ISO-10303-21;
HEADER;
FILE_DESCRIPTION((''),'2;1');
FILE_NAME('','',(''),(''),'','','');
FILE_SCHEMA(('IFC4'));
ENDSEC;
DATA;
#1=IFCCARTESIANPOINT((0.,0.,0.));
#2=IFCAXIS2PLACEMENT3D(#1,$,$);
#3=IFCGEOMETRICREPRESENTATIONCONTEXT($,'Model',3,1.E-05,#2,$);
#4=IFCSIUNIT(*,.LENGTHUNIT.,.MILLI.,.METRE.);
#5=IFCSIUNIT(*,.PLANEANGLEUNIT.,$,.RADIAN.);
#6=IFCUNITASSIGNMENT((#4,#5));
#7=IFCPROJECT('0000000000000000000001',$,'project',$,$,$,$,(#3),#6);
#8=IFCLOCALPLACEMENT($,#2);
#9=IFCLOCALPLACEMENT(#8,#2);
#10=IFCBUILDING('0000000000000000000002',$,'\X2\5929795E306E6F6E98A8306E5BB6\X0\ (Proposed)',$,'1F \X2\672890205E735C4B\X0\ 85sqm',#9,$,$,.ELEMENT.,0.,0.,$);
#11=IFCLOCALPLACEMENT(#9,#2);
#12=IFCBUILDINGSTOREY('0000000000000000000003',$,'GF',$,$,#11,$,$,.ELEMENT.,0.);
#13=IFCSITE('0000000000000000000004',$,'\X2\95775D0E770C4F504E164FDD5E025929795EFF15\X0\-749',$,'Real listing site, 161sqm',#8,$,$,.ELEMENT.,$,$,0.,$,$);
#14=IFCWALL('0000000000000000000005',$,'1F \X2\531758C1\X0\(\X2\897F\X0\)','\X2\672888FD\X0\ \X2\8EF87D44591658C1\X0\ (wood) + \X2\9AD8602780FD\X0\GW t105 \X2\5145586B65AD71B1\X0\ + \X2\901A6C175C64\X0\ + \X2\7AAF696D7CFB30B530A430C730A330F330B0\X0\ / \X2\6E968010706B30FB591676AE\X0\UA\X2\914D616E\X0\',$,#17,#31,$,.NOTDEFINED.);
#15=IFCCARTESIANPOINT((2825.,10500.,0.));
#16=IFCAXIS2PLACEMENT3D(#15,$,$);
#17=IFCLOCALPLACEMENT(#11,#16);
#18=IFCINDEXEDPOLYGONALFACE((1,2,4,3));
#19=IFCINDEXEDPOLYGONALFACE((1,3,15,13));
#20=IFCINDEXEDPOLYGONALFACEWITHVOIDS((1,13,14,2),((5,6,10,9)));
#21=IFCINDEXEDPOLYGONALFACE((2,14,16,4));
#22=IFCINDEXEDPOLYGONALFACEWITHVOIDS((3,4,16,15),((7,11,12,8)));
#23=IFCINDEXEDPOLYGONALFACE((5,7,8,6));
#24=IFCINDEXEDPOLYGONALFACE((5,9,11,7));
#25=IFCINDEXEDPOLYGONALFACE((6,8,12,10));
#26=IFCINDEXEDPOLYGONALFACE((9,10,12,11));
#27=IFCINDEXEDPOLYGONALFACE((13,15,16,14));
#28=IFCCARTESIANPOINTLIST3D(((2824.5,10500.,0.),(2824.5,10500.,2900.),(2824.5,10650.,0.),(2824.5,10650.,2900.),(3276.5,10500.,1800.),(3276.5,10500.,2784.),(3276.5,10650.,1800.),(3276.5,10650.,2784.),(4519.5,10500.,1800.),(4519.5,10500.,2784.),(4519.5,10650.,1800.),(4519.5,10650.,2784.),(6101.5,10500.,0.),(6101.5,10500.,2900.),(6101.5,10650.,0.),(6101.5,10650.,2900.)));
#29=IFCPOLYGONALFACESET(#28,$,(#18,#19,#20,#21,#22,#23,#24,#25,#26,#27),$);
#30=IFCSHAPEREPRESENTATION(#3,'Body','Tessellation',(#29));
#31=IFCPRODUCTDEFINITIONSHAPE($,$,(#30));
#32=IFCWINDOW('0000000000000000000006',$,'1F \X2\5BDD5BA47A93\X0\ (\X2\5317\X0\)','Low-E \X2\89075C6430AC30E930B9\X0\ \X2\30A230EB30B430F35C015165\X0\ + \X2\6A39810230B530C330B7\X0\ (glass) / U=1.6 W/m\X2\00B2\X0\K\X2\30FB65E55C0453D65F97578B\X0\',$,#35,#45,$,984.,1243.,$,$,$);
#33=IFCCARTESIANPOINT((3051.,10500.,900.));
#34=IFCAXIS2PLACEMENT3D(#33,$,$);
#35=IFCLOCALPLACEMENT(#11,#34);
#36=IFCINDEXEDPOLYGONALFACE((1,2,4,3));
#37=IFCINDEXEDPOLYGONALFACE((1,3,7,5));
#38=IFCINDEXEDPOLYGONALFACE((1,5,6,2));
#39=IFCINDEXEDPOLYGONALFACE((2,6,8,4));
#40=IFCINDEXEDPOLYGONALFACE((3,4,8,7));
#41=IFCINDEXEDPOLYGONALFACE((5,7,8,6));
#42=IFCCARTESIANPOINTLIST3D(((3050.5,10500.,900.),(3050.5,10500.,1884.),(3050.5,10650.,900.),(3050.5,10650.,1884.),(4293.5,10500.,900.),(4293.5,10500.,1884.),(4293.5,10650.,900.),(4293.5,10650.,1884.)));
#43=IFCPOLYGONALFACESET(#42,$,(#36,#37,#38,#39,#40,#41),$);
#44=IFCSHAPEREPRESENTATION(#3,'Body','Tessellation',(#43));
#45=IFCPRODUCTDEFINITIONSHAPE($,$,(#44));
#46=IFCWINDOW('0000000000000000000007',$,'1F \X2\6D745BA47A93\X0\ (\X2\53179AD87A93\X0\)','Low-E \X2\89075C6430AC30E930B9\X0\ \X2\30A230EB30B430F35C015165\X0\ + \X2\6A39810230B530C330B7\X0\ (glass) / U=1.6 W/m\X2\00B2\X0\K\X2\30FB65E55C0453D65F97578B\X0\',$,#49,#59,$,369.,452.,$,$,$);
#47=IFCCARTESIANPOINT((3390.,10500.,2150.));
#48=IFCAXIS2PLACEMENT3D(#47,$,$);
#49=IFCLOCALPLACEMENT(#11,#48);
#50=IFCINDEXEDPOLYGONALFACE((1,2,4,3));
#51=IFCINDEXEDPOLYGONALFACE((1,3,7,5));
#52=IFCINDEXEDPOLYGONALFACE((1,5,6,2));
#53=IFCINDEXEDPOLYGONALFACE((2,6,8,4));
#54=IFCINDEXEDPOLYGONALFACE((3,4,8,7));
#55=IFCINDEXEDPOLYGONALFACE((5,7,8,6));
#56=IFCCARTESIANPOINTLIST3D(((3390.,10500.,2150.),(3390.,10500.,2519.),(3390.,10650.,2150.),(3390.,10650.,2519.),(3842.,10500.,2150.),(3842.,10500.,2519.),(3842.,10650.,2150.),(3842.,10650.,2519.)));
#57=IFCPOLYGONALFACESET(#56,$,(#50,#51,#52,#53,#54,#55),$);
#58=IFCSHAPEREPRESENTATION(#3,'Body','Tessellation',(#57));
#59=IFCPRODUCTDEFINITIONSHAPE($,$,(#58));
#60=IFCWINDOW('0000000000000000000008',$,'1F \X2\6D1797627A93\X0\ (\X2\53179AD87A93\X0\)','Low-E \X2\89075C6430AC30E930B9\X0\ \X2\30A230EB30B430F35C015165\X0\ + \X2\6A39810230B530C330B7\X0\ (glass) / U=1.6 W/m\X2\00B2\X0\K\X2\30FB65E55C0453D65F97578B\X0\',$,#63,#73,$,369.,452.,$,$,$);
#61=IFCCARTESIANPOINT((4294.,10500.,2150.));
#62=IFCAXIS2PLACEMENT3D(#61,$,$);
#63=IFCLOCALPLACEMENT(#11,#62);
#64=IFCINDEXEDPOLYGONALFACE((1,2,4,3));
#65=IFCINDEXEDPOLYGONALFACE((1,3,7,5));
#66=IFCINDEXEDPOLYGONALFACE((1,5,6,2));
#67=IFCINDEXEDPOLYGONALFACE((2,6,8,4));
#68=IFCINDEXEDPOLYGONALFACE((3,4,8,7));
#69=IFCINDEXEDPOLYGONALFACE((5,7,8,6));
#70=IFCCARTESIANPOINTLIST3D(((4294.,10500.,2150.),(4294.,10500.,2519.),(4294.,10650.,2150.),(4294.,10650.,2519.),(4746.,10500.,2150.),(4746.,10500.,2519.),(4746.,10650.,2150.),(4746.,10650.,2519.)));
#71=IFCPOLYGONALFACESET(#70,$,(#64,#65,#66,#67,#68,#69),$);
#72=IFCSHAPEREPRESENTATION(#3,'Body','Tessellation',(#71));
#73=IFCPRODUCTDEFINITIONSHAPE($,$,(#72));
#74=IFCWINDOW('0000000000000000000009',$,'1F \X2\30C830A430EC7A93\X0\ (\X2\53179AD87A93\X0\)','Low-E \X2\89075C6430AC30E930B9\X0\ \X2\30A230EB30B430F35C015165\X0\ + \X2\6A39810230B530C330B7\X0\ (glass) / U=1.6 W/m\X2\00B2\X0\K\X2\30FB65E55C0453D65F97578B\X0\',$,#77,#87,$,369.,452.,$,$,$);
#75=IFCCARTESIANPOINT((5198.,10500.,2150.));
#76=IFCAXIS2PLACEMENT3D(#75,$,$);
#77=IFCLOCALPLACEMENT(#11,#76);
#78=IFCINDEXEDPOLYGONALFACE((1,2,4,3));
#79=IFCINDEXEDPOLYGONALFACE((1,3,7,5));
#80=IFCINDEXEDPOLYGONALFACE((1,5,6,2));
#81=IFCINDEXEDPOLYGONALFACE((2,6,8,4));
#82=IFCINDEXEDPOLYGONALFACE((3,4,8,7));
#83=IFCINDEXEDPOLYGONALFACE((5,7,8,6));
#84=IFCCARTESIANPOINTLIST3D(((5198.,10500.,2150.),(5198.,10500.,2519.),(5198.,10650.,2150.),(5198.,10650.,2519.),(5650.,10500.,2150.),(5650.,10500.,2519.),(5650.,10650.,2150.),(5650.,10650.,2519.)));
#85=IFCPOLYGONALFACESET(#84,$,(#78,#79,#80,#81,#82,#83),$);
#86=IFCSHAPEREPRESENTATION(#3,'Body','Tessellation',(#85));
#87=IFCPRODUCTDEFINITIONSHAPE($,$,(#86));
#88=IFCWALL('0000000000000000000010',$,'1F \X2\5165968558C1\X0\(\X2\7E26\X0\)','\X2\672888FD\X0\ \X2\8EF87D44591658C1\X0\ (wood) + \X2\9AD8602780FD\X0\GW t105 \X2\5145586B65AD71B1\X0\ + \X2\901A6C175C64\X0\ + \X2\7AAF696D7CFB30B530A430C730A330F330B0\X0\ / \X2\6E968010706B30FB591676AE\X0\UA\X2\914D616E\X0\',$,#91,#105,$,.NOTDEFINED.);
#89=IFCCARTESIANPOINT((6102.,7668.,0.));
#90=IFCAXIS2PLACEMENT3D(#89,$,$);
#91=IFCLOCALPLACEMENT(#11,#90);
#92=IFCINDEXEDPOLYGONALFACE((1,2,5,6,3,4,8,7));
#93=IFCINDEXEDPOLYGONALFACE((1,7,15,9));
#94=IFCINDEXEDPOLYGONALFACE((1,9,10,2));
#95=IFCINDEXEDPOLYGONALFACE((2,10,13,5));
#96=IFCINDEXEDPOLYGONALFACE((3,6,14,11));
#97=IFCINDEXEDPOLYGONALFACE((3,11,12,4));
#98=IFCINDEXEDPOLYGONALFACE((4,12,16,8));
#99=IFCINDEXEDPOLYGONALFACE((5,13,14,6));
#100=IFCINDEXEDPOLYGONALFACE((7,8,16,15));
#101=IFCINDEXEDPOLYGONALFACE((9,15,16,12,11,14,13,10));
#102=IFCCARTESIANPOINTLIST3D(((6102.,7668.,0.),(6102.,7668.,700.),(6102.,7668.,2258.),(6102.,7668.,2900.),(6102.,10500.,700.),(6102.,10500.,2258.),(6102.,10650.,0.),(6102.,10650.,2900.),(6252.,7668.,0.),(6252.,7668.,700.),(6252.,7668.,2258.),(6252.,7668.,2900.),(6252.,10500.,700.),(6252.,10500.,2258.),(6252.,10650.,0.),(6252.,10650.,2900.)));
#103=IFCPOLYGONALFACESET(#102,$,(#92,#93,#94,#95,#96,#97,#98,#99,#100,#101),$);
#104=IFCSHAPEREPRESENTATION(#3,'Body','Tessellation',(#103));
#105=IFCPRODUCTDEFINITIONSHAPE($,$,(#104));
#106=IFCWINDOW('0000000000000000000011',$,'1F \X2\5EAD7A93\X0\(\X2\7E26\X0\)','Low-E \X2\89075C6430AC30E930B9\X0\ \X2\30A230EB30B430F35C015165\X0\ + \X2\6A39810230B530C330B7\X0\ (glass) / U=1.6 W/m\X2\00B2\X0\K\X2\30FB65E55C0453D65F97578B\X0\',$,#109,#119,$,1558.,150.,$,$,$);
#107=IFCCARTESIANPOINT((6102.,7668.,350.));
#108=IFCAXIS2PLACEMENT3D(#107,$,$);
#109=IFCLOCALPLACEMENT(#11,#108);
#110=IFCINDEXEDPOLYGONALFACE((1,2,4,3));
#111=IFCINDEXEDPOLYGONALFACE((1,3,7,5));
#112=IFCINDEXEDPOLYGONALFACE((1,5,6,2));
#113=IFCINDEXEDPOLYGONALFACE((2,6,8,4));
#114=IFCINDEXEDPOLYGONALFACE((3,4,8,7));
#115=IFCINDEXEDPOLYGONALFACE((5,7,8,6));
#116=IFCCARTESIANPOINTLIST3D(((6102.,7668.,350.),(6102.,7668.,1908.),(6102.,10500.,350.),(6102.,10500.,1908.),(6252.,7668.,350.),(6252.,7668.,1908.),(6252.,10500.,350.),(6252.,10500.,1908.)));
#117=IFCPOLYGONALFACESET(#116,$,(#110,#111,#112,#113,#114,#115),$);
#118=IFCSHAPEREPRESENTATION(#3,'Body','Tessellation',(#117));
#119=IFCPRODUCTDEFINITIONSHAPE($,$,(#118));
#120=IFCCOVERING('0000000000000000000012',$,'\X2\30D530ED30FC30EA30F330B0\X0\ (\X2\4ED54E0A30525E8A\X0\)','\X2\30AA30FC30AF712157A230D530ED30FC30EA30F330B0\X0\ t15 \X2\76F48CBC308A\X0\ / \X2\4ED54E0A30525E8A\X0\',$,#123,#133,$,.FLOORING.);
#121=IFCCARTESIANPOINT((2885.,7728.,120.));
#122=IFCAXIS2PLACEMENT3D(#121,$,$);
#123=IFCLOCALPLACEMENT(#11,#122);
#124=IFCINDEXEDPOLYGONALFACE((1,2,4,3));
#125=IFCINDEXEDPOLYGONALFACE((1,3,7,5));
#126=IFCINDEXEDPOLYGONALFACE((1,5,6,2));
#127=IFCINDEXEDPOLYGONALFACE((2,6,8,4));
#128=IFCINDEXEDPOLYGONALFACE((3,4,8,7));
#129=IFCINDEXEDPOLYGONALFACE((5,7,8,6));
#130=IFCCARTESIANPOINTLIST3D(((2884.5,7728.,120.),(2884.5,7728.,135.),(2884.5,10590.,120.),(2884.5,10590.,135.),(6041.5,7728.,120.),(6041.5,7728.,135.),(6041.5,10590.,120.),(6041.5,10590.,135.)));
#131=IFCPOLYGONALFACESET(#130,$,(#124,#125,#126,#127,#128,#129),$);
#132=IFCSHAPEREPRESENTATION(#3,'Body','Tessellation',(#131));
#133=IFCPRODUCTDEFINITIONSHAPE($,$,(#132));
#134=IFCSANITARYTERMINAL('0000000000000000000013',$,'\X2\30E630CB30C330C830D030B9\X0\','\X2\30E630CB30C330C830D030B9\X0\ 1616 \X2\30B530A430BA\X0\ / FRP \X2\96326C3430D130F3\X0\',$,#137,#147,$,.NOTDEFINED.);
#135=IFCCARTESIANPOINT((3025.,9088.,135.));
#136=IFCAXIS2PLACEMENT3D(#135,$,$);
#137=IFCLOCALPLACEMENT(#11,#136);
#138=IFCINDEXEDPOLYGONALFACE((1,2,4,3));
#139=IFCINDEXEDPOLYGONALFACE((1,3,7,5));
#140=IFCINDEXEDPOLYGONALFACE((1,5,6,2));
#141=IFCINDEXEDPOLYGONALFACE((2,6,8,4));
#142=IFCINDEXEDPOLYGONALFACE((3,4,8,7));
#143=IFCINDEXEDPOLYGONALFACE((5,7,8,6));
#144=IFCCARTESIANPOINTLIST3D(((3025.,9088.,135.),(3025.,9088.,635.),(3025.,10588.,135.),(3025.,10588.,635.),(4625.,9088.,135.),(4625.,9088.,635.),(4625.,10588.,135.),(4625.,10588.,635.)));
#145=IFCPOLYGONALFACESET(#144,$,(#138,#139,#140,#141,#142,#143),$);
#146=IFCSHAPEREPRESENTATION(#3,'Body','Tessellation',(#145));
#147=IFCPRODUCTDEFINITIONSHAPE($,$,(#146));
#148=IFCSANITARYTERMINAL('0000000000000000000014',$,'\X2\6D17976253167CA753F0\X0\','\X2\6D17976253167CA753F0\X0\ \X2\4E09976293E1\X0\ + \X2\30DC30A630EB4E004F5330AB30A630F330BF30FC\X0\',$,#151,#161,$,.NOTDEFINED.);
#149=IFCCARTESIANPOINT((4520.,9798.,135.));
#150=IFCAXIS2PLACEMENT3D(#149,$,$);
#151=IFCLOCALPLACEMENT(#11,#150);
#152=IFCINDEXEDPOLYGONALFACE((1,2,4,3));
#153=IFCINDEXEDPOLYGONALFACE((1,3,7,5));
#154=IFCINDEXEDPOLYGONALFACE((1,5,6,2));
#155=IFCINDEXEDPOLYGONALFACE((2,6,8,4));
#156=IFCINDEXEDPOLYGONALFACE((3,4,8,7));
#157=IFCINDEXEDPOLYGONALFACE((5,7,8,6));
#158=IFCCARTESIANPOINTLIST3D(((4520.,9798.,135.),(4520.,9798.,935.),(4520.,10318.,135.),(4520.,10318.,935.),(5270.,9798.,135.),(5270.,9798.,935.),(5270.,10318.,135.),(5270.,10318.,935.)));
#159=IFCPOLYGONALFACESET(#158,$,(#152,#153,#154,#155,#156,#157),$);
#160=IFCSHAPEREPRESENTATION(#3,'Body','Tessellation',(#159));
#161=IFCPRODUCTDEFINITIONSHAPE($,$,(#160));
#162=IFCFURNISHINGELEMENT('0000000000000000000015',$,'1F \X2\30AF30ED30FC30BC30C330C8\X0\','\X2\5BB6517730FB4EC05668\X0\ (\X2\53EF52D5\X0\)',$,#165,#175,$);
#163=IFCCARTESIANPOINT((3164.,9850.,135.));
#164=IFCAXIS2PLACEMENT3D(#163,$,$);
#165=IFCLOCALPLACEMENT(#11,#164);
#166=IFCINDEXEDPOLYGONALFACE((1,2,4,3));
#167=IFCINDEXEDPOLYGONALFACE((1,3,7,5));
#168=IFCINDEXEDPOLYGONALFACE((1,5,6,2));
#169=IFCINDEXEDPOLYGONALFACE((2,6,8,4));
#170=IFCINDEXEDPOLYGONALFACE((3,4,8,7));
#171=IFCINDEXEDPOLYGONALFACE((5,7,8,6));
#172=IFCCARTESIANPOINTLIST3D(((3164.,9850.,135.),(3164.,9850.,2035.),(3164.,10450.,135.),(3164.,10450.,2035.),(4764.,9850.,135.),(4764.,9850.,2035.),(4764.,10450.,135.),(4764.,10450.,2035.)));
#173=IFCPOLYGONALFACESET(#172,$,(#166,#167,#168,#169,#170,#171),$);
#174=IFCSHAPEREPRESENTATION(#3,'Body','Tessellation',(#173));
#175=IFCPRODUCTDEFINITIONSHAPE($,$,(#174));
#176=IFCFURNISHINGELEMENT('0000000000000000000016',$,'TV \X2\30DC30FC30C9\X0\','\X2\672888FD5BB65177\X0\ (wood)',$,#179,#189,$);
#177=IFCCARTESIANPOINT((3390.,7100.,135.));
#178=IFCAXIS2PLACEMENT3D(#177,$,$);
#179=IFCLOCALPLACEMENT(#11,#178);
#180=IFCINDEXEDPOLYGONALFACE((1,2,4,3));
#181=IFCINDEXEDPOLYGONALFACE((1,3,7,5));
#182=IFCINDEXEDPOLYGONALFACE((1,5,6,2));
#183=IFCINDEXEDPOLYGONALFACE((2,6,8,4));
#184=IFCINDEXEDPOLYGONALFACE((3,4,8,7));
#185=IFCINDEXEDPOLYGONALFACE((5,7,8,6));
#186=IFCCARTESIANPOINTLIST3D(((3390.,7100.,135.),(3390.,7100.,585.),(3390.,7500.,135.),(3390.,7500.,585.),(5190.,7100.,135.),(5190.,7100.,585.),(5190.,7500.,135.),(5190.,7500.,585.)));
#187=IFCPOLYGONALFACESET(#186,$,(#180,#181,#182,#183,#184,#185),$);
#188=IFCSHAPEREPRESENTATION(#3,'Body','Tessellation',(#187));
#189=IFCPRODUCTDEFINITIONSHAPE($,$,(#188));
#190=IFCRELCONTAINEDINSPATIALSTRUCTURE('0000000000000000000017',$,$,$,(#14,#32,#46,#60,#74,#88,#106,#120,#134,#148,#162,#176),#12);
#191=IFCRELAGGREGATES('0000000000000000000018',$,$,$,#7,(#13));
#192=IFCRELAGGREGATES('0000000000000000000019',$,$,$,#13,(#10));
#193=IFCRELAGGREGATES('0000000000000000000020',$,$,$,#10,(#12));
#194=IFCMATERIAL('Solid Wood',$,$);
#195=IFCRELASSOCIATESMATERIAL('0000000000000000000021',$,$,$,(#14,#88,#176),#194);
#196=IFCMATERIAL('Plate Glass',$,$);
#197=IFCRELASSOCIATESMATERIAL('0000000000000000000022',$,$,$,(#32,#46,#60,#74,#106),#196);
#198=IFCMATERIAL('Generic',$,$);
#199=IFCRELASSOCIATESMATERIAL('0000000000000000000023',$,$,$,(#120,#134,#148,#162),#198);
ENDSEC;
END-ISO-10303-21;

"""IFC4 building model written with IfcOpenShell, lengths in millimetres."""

from ifc_helpers import new_model, si_unit, frame, frame_2d, origin, place, context, project, spatial, rectangle, extrude, material, element, fill, save


model = new_model("IFC4")

# Units and contexts
model_context = context("Model", 3, precision=1e-05, world=origin())
ifc_project = project(units=[si_unit("LENGTHUNIT", "METRE", prefix="MILLI"), si_unit("PLANEANGLEUNIT", "RADIAN")], contexts=[model_context])

# Site, building, storey
site_placement = place(None, origin())
site = spatial("IfcSite", under=ifc_project, at=site_placement, Name="長崎県佐世保市天神５-749", ObjectType="Real listing site, 161sqm", CompositionType="ELEMENT", RefElevation=0.0)
building_placement = place(site_placement, origin())
building = spatial("IfcBuilding", under=site, at=building_placement, Name="天神の潮風の家 (Proposed)", ObjectType="1F 木造平屋 85sqm", CompositionType="ELEMENT", ElevationOfRefHeight=0.0, ElevationOfTerrain=0.0)
storey_placement = place(building_placement, origin())
storey = spatial("IfcBuildingStorey", under=building, at=storey_placement, Name="GF", CompositionType="ELEMENT", Elevation=0.0)

# Shared definitions
ifc_material_1 = material(Name="Solid Wood")

# Wall, openings, windows
wall_1_placement = place(storey_placement, frame((2825.0, 10500.0, 0.0)))
wall_1 = element("IfcWall", 1, at=wall_1_placement, inside=storey, material=ifc_material_1, Name="1F 北壁(西)", Description="木製 軸組外壁 (wood) + 高性能GW t105 充填断熱 + 通気層 + 窯業系サイディング / 準耐火・外皮UA配慮", PredefinedType="NOTDEFINED", context=model_context, shape_type="SweptSolid", body=[
    extrude(rectangle(XDim=3277.0, YDim=150.0, at=frame_2d((1638.0, 75.0))), frame((2825.0, 10500.0, 0.0)), (0.0, 0.0, 1.0), 2900.0),
])
opening_1_placement = place(storey_placement, frame((3051.0, 10500.0, 900.0)))
opening_1 = element("IfcOpeningElement", 2, at=opening_1_placement, cuts=wall_1, PredefinedType="NOTDEFINED", context=model_context, shape_type="SweptSolid", body=[
    extrude(rectangle(XDim=1243.0, YDim=150.0, at=frame_2d((621.0, 75.0))), frame((3051.0, 10500.0, 900.0)), (0.0, 0.0, 1.0), 984.0),
])
opening_2_placement = place(storey_placement, frame((3390.0, 10500.0, 2150.0)))
opening_2 = element("IfcOpeningElement", 3, at=opening_2_placement, cuts=wall_1, PredefinedType="NOTDEFINED", context=model_context, shape_type="SweptSolid", body=[
    extrude(rectangle(XDim=452.0, YDim=150.0, at=frame_2d((226.0, 75.0))), frame((3390.0, 10500.0, 2150.0)), (0.0, 0.0, 1.0), 369.0),
])
opening_3_placement = place(storey_placement, frame((4294.0, 10500.0, 2150.0)))
opening_3 = element("IfcOpeningElement", 4, at=opening_3_placement, cuts=wall_1, PredefinedType="NOTDEFINED", context=model_context, shape_type="SweptSolid", body=[
    extrude(rectangle(XDim=452.0, YDim=150.0, at=frame_2d((226.0, 75.0))), frame((4294.0, 10500.0, 2150.0)), (0.0, 0.0, 1.0), 369.0),
])
opening_4_placement = place(storey_placement, frame((5198.0, 10500.0, 2150.0)))
opening_4 = element("IfcOpeningElement", 5, at=opening_4_placement, cuts=wall_1, PredefinedType="NOTDEFINED", context=model_context, shape_type="SweptSolid", body=[
    extrude(rectangle(XDim=452.0, YDim=150.0, at=frame_2d((226.0, 75.0))), frame((5198.0, 10500.0, 2150.0)), (0.0, 0.0, 1.0), 369.0),
])
ifc_material_2 = material(Name="Plate Glass")
window_1_placement = place(storey_placement, frame((3051.0, 10500.0, 900.0)))
window_1 = element("IfcWindow", 6, at=window_1_placement, inside=storey, material=ifc_material_2, Name="1F 寝室窓 (北)", Description="Low-E 複層ガラス アルゴン封入 + 樹脂サッシ (glass) / U=1.6 W/m²K・日射取得型", OverallHeight=984.0, OverallWidth=1243.0, context=model_context, shape_type="SweptSolid", body=[
    extrude(rectangle(XDim=1243.0, YDim=150.0, at=frame_2d((621.0, 75.0))), frame((3051.0, 10500.0, 900.0)), (0.0, 0.0, 1.0), 984.0),
])
fill(opening_1, window_1)
window_2_placement = place(storey_placement, frame((3390.0, 10500.0, 2150.0)))
window_2 = element("IfcWindow", 7, at=window_2_placement, inside=storey, material=ifc_material_2, Name="1F 浴室窓 (北高窓)", Description="Low-E 複層ガラス アルゴン封入 + 樹脂サッシ (glass) / U=1.6 W/m²K・日射取得型", OverallHeight=369.0, OverallWidth=452.0, context=model_context, shape_type="SweptSolid", body=[
    extrude(rectangle(XDim=452.0, YDim=150.0, at=frame_2d((226.0, 75.0))), frame((3390.0, 10500.0, 2150.0)), (0.0, 0.0, 1.0), 369.0),
])
fill(opening_2, window_2)
window_3_placement = place(storey_placement, frame((4294.0, 10500.0, 2150.0)))
window_3 = element("IfcWindow", 8, at=window_3_placement, inside=storey, material=ifc_material_2, Name="1F 洗面窓 (北高窓)", Description="Low-E 複層ガラス アルゴン封入 + 樹脂サッシ (glass) / U=1.6 W/m²K・日射取得型", OverallHeight=369.0, OverallWidth=452.0, context=model_context, shape_type="SweptSolid", body=[
    extrude(rectangle(XDim=452.0, YDim=150.0, at=frame_2d((226.0, 75.0))), frame((4294.0, 10500.0, 2150.0)), (0.0, 0.0, 1.0), 369.0),
])
fill(opening_3, window_3)
window_4_placement = place(storey_placement, frame((5198.0, 10500.0, 2150.0)))
window_4 = element("IfcWindow", 9, at=window_4_placement, inside=storey, material=ifc_material_2, Name="1F トイレ窓 (北高窓)", Description="Low-E 複層ガラス アルゴン封入 + 樹脂サッシ (glass) / U=1.6 W/m²K・日射取得型", OverallHeight=369.0, OverallWidth=452.0, context=model_context, shape_type="SweptSolid", body=[
    extrude(rectangle(XDim=452.0, YDim=150.0, at=frame_2d((226.0, 75.0))), frame((5198.0, 10500.0, 2150.0)), (0.0, 0.0, 1.0), 369.0),
])
fill(opening_4, window_4)

# Wall, opening, window
wall_2_placement = place(storey_placement, frame((6102.0, 7668.0, 0.0)))
wall_2 = element("IfcWall", 10, at=wall_2_placement, inside=storey, material=ifc_material_1, Name="1F 入隅壁(縦)", Description="木製 軸組外壁 (wood) + 高性能GW t105 充填断熱 + 通気層 + 窯業系サイディング / 準耐火・外皮UA配慮", PredefinedType="NOTDEFINED", context=model_context, shape_type="SweptSolid", body=[
    extrude(rectangle(XDim=150.0, YDim=2982.0, at=frame_2d((75.0, 1491.0))), frame((6102.0, 7668.0, 0.0)), (0.0, 0.0, 1.0), 2900.0),
])
opening_5_placement = place(storey_placement, frame((6102.0, 7668.0, 350.0)))
opening_5 = element("IfcOpeningElement", 11, at=opening_5_placement, cuts=wall_2, PredefinedType="NOTDEFINED", context=model_context, shape_type="SweptSolid", body=[
    extrude(rectangle(XDim=150.0, YDim=2832.0, at=frame_2d((75.0, 1416.0))), frame((6102.0, 7668.0, 350.0)), (0.0, 0.0, 1.0), 1558.0),
])
window_5_placement = place(storey_placement, frame((6102.0, 7668.0, 350.0)))
window_5 = element("IfcWindow", 12, at=window_5_placement, inside=storey, material=ifc_material_2, Name="1F 庭窓(縦)", Description="Low-E 複層ガラス アルゴン封入 + 樹脂サッシ (glass) / U=1.6 W/m²K・日射取得型", OverallHeight=1558.0, OverallWidth=150.0, context=model_context, shape_type="SweptSolid", body=[
    extrude(rectangle(XDim=150.0, YDim=2832.0, at=frame_2d((75.0, 1416.0))), frame((6102.0, 7668.0, 350.0)), (0.0, 0.0, 1.0), 1558.0),
])
fill(opening_5, window_5)

# Covering
ifc_material_3 = material(Name="Generic")
covering_placement = place(storey_placement, frame((2885.0, 7728.0, 120.0)))
element("IfcCovering", 13, at=covering_placement, inside=storey, material=ifc_material_3, Name="フローリング (仕上げ床)", Description="オーク無垢フローリング t15 直貼り / 仕上げ床", PredefinedType="FLOORING", context=model_context, shape_type="SweptSolid", body=[
    extrude(rectangle(XDim=3157.0, YDim=2862.0, at=frame_2d((1578.0, 1431.0))), frame((2885.0, 7728.0, 120.0)), (0.0, 0.0, 1.0), 15.0),
])

# Sanitary terminals
sanitary_terminal_1_placement = place(storey_placement, frame((3025.0, 9088.0, 135.0)))
element("IfcSanitaryTerminal", 14, at=sanitary_terminal_1_placement, inside=storey, material=ifc_material_3, Name="ユニットバス", Description="ユニットバス 1616 サイズ / FRP 防水パン", PredefinedType="NOTDEFINED", context=model_context, shape_type="SweptSolid", body=[
    extrude(rectangle(XDim=1600.0, YDim=1500.0, at=frame_2d((800.0, 750.0))), frame((3025.0, 9088.0, 135.0)), (0.0, 0.0, 1.0), 500.0),
])
sanitary_terminal_2_placement = place(storey_placement, frame((4520.0, 9798.0, 135.0)))
element("IfcSanitaryTerminal", 15, at=sanitary_terminal_2_placement, inside=storey, material=ifc_material_3, Name="洗面化粧台", Description="洗面化粧台 三面鏡 + ボウル一体カウンター", PredefinedType="NOTDEFINED", context=model_context, shape_type="SweptSolid", body=[
    extrude(rectangle(XDim=750.0, YDim=520.0, at=frame_2d((375.0, 260.0))), frame((4520.0, 9798.0, 135.0)), (0.0, 0.0, 1.0), 800.0),
])

# Furnishing elements
furnishing_1_placement = place(storey_placement, frame((3164.0, 9850.0, 135.0)))
element("IfcFurnishingElement", 16, at=furnishing_1_placement, inside=storey, material=ifc_material_3, Name="1F クローゼット", Description="家具・什器 (可動)", context=model_context, shape_type="SweptSolid", body=[
    extrude(rectangle(XDim=1600.0, YDim=600.0, at=frame_2d((800.0, 300.0))), frame((3164.0, 9850.0, 135.0)), (0.0, 0.0, 1.0), 1900.0),
])
furnishing_2_placement = place(storey_placement, frame((3390.0, 7100.0, 135.0)))
element("IfcFurnishingElement", 17, at=furnishing_2_placement, inside=storey, material=ifc_material_1, Name="TV ボード", Description="木製家具 (wood)", context=model_context, shape_type="SweptSolid", body=[
    extrude(rectangle(XDim=1800.0, YDim=400.0, at=frame_2d((900.0, 200.0))), frame((3390.0, 7100.0, 135.0)), (0.0, 0.0, 1.0), 450.0),
])

save(model, "model.ifc")
